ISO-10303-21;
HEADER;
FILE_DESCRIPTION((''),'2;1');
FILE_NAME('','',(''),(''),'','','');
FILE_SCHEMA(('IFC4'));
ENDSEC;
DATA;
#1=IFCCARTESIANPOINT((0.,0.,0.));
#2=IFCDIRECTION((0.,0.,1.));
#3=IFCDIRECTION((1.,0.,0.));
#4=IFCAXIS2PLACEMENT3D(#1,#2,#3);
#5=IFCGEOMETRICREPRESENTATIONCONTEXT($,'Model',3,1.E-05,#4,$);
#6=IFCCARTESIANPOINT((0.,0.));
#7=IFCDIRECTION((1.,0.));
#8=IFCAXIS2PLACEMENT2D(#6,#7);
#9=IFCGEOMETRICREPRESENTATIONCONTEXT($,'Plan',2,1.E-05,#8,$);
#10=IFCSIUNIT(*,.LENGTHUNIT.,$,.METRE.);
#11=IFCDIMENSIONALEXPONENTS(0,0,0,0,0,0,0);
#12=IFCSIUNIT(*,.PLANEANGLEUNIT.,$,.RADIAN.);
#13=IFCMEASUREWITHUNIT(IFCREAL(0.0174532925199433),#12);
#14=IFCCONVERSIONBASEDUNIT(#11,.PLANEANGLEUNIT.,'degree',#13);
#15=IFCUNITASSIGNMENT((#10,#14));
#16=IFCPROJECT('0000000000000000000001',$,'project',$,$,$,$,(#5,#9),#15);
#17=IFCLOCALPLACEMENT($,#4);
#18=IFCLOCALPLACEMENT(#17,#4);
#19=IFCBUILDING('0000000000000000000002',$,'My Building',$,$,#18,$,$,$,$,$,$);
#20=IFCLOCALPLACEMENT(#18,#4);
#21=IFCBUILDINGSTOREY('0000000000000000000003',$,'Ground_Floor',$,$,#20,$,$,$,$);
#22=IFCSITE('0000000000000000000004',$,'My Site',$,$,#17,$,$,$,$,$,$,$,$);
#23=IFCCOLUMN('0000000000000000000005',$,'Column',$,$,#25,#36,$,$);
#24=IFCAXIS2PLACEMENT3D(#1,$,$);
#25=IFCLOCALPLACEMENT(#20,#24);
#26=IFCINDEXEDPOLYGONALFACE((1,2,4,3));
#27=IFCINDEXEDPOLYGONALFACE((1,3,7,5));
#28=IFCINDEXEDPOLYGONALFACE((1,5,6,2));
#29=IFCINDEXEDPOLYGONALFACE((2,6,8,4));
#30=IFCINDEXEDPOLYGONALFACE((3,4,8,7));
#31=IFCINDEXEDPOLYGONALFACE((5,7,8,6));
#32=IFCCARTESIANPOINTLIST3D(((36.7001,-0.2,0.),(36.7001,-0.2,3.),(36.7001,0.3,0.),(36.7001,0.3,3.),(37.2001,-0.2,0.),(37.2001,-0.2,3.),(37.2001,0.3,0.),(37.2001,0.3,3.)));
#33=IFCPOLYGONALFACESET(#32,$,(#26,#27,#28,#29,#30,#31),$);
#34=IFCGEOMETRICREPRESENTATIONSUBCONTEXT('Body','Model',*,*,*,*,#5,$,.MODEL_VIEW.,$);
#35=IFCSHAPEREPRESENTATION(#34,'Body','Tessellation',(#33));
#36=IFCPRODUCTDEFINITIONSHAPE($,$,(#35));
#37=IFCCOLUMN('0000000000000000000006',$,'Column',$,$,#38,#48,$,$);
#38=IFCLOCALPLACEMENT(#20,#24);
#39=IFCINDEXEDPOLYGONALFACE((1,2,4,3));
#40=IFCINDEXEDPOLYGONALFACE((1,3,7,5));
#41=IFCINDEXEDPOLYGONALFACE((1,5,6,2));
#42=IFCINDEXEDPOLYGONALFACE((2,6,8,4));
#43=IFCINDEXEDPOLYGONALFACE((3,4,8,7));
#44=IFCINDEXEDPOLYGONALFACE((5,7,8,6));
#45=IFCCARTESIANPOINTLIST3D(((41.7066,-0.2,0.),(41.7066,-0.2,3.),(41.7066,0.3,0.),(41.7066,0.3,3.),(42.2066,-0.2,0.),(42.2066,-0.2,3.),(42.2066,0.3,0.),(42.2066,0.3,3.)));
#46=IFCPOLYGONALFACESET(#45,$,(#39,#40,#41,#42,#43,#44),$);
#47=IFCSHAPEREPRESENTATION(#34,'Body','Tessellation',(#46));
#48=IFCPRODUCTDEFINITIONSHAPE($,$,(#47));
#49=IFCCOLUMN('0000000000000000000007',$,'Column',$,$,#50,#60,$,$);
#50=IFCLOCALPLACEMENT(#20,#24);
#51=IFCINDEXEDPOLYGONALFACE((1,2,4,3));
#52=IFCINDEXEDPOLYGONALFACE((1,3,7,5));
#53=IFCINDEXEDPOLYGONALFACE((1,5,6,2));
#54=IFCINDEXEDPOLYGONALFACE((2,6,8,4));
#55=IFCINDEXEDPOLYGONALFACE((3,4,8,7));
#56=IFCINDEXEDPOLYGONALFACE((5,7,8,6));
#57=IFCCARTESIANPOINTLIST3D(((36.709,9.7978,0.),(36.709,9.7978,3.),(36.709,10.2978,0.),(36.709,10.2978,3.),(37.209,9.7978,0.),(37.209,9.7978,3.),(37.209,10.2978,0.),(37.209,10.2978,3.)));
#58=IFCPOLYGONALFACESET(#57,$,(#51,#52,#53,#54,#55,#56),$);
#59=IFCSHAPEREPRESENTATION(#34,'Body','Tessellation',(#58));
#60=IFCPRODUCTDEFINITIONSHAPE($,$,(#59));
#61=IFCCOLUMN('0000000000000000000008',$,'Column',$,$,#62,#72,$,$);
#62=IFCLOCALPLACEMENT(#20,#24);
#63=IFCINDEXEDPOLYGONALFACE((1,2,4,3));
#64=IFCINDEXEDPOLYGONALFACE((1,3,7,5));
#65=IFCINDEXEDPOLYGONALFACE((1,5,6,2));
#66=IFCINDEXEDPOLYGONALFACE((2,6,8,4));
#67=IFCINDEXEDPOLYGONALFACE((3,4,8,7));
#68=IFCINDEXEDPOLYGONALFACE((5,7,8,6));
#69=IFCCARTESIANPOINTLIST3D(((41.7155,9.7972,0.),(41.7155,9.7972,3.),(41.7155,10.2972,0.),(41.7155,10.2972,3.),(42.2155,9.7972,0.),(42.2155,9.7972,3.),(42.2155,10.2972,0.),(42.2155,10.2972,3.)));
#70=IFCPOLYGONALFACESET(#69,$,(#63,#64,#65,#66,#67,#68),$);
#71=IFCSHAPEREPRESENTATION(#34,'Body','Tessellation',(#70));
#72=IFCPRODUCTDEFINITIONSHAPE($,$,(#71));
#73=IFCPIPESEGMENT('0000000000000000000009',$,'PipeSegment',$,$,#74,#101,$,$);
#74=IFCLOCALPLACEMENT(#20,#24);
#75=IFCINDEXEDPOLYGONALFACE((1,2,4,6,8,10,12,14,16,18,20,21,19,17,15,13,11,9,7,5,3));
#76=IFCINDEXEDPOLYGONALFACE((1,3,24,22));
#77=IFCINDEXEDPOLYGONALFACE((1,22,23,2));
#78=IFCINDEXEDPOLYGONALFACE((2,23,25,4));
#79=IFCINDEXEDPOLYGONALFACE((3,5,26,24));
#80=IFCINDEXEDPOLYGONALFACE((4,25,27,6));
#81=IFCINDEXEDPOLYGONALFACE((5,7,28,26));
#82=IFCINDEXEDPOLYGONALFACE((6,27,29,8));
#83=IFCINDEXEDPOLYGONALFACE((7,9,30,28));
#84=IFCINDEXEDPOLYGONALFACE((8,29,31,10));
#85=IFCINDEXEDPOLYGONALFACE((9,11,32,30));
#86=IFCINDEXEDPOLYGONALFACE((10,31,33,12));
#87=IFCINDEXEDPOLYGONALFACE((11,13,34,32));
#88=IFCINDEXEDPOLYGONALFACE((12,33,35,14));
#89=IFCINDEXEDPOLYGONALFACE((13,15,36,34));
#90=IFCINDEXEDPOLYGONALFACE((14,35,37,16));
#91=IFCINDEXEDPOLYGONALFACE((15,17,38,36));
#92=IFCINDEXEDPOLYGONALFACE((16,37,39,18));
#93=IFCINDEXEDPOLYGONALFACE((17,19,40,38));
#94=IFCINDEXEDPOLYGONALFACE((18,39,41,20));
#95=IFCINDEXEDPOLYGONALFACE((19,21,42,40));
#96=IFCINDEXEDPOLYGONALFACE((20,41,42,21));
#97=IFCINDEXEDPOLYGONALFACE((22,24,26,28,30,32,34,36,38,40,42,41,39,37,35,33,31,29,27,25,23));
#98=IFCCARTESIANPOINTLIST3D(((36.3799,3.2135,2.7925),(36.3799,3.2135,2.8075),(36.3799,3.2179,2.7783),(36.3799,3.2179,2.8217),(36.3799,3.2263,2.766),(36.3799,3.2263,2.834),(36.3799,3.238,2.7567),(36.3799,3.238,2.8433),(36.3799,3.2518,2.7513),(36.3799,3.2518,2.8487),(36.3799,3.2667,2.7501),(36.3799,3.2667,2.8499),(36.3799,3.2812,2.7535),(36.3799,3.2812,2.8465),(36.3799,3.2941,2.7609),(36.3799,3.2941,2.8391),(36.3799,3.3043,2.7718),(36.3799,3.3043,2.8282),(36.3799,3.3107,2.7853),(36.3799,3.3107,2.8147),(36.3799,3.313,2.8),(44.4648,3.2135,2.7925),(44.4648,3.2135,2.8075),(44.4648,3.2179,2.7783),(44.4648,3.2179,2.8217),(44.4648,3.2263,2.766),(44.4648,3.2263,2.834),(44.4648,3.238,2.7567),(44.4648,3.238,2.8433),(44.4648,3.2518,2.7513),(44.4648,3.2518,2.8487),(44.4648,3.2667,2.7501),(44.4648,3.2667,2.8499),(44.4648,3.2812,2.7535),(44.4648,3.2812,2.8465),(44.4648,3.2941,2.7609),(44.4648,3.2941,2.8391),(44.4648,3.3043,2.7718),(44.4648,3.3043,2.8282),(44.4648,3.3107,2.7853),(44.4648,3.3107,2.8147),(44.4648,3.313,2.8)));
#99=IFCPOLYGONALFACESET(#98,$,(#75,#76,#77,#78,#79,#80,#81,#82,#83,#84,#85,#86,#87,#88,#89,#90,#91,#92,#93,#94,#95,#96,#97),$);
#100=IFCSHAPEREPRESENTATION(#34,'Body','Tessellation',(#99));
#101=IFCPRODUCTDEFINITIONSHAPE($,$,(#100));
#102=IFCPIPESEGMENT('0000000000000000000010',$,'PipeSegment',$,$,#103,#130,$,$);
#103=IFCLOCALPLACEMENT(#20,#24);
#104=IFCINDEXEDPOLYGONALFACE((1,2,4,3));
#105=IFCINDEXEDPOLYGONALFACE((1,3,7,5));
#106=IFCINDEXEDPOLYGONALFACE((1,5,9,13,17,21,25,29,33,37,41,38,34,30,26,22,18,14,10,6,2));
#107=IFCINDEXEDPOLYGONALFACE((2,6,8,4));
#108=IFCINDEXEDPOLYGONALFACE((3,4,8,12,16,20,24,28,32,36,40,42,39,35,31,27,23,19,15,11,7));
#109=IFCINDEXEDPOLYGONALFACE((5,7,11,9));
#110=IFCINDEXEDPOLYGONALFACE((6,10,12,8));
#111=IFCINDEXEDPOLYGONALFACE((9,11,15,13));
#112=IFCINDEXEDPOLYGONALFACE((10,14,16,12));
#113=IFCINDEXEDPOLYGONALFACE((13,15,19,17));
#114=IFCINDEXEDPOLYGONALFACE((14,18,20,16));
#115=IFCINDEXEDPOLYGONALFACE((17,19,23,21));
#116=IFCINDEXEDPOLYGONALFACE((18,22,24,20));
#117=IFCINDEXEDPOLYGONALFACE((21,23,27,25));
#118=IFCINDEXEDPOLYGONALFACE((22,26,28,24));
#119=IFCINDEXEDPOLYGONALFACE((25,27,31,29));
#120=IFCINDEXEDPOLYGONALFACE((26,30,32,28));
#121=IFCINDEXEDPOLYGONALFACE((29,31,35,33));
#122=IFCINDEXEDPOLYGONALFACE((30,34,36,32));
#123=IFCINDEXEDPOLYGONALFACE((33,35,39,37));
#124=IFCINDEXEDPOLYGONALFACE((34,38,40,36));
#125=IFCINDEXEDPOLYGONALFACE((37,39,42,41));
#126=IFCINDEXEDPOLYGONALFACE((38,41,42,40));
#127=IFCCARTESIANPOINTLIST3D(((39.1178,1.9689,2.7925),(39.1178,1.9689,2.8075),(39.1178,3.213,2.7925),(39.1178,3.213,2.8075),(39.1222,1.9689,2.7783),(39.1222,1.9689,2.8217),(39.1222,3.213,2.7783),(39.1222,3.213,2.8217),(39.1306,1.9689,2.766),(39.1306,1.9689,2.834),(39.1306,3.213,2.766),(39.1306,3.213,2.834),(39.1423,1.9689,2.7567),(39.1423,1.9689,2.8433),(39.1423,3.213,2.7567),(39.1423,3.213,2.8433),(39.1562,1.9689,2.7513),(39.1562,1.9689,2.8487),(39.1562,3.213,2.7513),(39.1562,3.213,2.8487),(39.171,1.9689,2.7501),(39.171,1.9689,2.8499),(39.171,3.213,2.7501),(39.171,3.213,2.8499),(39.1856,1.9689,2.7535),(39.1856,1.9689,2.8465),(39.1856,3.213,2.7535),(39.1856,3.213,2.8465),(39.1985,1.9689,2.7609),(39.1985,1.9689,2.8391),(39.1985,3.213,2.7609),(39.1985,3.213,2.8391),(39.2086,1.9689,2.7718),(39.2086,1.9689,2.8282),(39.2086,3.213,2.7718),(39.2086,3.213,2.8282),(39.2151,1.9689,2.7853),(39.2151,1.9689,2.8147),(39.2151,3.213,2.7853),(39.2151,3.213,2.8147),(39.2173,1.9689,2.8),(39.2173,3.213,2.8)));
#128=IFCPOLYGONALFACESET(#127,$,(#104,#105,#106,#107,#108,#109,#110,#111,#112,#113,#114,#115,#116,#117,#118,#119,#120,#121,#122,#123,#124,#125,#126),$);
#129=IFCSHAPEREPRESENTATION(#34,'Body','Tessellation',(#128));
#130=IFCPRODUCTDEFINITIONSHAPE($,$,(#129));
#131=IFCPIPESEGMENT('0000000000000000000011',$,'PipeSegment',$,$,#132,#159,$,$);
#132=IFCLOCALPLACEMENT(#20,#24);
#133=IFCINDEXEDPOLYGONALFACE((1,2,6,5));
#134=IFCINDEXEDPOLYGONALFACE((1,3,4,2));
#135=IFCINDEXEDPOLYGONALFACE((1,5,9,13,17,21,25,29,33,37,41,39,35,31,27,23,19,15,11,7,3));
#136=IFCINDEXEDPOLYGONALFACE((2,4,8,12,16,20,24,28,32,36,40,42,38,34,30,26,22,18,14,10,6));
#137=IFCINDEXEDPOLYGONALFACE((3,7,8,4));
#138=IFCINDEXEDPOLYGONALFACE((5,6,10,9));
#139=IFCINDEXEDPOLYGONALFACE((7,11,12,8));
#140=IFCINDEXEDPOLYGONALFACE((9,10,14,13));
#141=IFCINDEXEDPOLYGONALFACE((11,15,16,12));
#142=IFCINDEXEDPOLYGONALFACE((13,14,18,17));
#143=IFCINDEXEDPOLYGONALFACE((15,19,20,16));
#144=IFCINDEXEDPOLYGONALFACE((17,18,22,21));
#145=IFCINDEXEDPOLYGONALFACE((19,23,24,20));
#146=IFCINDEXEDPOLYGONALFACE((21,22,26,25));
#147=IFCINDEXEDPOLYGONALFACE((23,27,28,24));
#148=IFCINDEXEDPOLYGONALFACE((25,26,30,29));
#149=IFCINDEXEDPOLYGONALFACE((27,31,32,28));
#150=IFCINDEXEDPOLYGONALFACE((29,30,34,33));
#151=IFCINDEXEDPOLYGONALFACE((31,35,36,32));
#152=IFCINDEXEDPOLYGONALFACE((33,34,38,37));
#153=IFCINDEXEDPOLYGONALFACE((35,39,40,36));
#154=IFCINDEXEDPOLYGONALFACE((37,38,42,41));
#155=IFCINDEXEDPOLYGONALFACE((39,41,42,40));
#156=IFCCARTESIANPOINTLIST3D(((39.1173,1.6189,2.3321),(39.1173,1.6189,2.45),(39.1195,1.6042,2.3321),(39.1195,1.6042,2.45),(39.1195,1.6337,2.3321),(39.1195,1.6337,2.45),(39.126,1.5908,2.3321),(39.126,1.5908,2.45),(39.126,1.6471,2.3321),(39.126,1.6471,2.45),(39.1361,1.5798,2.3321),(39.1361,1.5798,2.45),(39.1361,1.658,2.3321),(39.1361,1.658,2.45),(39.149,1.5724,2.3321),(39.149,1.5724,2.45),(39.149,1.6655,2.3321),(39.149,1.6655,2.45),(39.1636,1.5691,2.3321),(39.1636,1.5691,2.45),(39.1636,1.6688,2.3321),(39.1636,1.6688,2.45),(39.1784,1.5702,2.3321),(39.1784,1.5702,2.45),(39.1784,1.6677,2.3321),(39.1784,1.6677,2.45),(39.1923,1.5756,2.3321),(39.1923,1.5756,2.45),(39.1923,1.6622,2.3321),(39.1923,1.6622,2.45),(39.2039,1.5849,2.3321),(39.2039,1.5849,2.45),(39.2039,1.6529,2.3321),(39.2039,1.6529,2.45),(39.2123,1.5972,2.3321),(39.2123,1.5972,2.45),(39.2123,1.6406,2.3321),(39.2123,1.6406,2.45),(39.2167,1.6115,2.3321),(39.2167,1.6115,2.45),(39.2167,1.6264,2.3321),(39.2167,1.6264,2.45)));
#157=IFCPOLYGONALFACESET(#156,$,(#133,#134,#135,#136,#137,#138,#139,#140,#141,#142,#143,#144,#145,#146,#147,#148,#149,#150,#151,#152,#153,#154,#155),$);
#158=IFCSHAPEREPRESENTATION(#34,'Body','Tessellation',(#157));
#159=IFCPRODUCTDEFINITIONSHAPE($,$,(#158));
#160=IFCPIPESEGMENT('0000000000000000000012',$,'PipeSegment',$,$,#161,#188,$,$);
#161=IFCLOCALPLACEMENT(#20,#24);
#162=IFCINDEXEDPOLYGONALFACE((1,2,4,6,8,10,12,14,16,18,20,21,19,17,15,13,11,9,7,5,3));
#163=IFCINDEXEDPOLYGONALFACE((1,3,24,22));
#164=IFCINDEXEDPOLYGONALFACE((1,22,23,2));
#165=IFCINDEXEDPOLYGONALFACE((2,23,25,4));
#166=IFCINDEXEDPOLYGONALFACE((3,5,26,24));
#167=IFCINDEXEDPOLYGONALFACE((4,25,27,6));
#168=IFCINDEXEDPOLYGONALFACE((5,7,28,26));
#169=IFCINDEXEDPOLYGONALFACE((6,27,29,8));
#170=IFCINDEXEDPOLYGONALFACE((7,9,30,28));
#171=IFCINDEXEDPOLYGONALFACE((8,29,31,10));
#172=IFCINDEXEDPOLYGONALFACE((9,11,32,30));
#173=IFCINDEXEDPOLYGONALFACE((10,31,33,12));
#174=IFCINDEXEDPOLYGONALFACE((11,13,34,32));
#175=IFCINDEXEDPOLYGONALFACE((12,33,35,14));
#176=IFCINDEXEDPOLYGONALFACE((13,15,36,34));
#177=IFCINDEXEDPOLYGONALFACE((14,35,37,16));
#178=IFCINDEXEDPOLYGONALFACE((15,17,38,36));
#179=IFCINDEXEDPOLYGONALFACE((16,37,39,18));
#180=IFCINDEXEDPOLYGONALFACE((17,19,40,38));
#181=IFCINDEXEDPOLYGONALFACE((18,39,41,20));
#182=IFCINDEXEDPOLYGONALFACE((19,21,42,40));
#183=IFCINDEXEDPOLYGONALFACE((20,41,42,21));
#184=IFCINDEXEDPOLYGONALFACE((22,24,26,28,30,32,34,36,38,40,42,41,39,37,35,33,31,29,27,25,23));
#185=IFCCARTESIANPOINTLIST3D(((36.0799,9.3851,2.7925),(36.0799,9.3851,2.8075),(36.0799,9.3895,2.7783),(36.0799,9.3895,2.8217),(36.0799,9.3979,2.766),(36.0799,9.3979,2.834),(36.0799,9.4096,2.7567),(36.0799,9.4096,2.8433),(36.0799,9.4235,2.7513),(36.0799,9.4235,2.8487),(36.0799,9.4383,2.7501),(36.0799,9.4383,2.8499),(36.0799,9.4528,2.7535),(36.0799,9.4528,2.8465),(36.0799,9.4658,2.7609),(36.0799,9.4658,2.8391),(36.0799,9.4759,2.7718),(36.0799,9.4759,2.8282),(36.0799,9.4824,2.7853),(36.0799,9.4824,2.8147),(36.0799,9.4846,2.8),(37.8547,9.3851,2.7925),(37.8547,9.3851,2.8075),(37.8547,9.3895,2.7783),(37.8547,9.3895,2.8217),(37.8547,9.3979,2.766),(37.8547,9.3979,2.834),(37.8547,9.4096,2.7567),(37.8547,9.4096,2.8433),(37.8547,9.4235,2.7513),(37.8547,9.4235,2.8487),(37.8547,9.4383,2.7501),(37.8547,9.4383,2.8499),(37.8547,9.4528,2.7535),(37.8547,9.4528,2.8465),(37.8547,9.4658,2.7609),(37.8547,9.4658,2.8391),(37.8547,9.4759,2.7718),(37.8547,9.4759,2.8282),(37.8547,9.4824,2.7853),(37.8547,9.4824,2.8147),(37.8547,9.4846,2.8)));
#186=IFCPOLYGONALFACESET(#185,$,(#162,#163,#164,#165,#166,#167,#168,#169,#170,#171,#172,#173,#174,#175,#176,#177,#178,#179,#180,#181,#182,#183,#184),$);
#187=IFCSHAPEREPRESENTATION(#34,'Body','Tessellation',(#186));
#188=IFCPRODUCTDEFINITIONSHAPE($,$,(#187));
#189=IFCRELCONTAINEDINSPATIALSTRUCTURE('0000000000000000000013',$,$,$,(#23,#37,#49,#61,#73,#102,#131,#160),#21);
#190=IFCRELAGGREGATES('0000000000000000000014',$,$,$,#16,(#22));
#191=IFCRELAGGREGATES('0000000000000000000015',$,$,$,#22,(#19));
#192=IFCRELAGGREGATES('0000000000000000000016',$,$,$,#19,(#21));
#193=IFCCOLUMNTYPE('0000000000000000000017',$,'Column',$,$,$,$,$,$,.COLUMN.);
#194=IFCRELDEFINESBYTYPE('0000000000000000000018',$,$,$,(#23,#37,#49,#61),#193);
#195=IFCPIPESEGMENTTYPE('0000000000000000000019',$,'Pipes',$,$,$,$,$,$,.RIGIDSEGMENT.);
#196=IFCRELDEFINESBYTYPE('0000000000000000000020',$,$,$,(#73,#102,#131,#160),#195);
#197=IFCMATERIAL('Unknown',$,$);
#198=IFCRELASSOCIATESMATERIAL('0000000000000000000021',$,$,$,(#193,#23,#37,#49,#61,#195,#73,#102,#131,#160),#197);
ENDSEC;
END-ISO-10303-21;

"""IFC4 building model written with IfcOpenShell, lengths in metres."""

from ifc_helpers import new_model, entity, si_unit, converted_unit, frame, origin_with_axes, origin_2d_with_axis, place, context, subcontext, project, spatial, rectangle, circle, extrude, material, material_profile, profile_set, profile_usage, type_object, element, save


model = new_model("IFC4")

# Units and contexts
model_context = context("Model", 3, precision=1e-05, world=origin_with_axes())
plan_context = context("Plan", 2, precision=1e-05, world=origin_2d_with_axis())
body_context = subcontext(model_context, "Body", "Model", "MODEL_VIEW")
ifc_project = project(units=[si_unit("LENGTHUNIT", "METRE"), converted_unit("PLANEANGLEUNIT", "degree", entity("IfcReal", 0.0174532925199433), si_unit("PLANEANGLEUNIT", "RADIAN"), dimensions=[0, 0, 0, 0, 0, 0, 0])], contexts=[model_context, plan_context])

# Site, building, storey
site_placement = place(None, origin_with_axes())
site = spatial("IfcSite", under=ifc_project, at=site_placement, Name="My Site")
building_placement = place(site_placement, origin_with_axes())
building = spatial("IfcBuilding", under=site, at=building_placement, Name="My Building")
storey_placement = place(building_placement, origin_with_axes())
storey = spatial("IfcBuildingStorey", under=building, at=storey_placement, Name="Ground_Floor")

# Columns
ifc_material = material(Name="Unknown")
ifc_material_profile_1 = material_profile(ifc_material, rectangle(XDim=0.5, YDim=0.5))
ifc_profile_set_1 = profile_set([ifc_material_profile_1])
ifc_profile_usage_1 = profile_usage(ifc_profile_set_1, cardinal=5)
column_type = type_object("IfcColumnType", Name="Column", PredefinedType="COLUMN", material=ifc_profile_set_1)
column_1_placement = place(storey_placement, frame((36.9501, 0.05, 0.0), z_axis=(0.0, 0.0, 1.0), x_axis=(1.0, 0.0, 0.0)))
element("IfcColumn", 1, at=column_1_placement, inside=storey, type_object=column_type, material=ifc_profile_usage_1, Name="Column", context=body_context, shape_type="SweptSolid", body=[
    extrude(rectangle(XDim=0.5, YDim=0.5), origin_with_axes(), (0.0, 0.0, 1.0), 3.0),
])
ifc_profile_usage_2 = profile_usage(ifc_profile_set_1, cardinal=5)
column_2_placement = place(storey_placement, frame((41.9566, 0.05, 0.0), z_axis=(0.0, 0.0, 1.0), x_axis=(1.0, 0.0, 0.0)))
element("IfcColumn", 2, at=column_2_placement, inside=storey, type_object=column_type, material=ifc_profile_usage_2, Name="Column", context=body_context, shape_type="SweptSolid", body=[
    extrude(rectangle(XDim=0.5, YDim=0.5), origin_with_axes(), (0.0, 0.0, 1.0), 3.0),
])
ifc_profile_usage_3 = profile_usage(ifc_profile_set_1, cardinal=5)
column_3_placement = place(storey_placement, frame((36.959, 10.0478, 0.0), z_axis=(0.0, 0.0, 1.0), x_axis=(1.0, 0.0, 0.0)))
element("IfcColumn", 3, at=column_3_placement, inside=storey, type_object=column_type, material=ifc_profile_usage_3, Name="Column", context=body_context, shape_type="SweptSolid", body=[
    extrude(rectangle(XDim=0.5, YDim=0.5), origin_with_axes(), (0.0, 0.0, 1.0), 3.0),
])
ifc_profile_usage_4 = profile_usage(ifc_profile_set_1, cardinal=5)
column_4_placement = place(storey_placement, frame((41.9655, 10.0472, 0.0), z_axis=(0.0, 0.0, 1.0), x_axis=(1.0, 0.0, 0.0)))
element("IfcColumn", 4, at=column_4_placement, inside=storey, type_object=column_type, material=ifc_profile_usage_4, Name="Column", context=body_context, shape_type="SweptSolid", body=[
    extrude(rectangle(XDim=0.5, YDim=0.5), origin_with_axes(), (0.0, 0.0, 1.0), 3.0),
])

# Pipe segments
ifc_material_profile_2 = material_profile(ifc_material, circle(Radius=0.05))
ifc_profile_set_2 = profile_set([ifc_material_profile_2])
ifc_profile_usage_5 = profile_usage(ifc_profile_set_2, cardinal=5)
pipe_segment_type = type_object("IfcPipeSegmentType", Name="Pipes", PredefinedType="RIGIDSEGMENT", material=ifc_profile_set_2)
pipe_segment_1_placement = place(storey_placement, frame((36.3799, 3.263, 2.8), z_axis=(1.0, 0.0, 0.0), x_axis=(0.0, 1.0, 0.0)))
element("IfcPipeSegment", 5, at=pipe_segment_1_placement, inside=storey, type_object=pipe_segment_type, material=ifc_profile_usage_5, Name="PipeSegment", context=body_context, shape_type="SweptSolid", body=[
    extrude(circle(Radius=0.05), origin_with_axes(), (0.0, 0.0, 1.0), 8.0849),
])
ifc_profile_usage_6 = profile_usage(ifc_profile_set_2, cardinal=5)
pipe_segment_2_placement = place(storey_placement, frame((39.1673, 3.213, 2.8), z_axis=(0.0, -1.0, 0.0), x_axis=(1.0, 0.0, 0.0)))
element("IfcPipeSegment", 6, at=pipe_segment_2_placement, inside=storey, type_object=pipe_segment_type, material=ifc_profile_usage_6, Name="PipeSegment", context=body_context, shape_type="SweptSolid", body=[
    extrude(circle(Radius=0.05), origin_with_axes(), (0.0, 0.0, 1.0), 1.244),
])
ifc_profile_usage_7 = profile_usage(ifc_profile_set_2, cardinal=5)
pipe_segment_3_placement = place(storey_placement, frame((39.1673, 1.6189, 2.45), z_axis=(0.0, 0.0, -1.0), x_axis=(-1.0, 0.0, 0.0)))
element("IfcPipeSegment", 7, at=pipe_segment_3_placement, inside=storey, type_object=pipe_segment_type, material=ifc_profile_usage_7, Name="PipeSegment", context=body_context, shape_type="SweptSolid", body=[
    extrude(circle(Radius=0.05), origin_with_axes(), (0.0, 0.0, 1.0), 0.1179),
])
ifc_profile_usage_8 = profile_usage(ifc_profile_set_2, cardinal=5)
pipe_segment_4_placement = place(storey_placement, frame((36.0799, 9.4346, 2.8), z_axis=(1.0, 0.0, 0.0), x_axis=(0.0, 1.0, 0.0)))
element("IfcPipeSegment", 8, at=pipe_segment_4_placement, inside=storey, type_object=pipe_segment_type, material=ifc_profile_usage_8, Name="PipeSegment", context=body_context, shape_type="SweptSolid", body=[
    extrude(circle(Radius=0.05), origin_with_axes(), (0.0, 0.0, 1.0), 1.7748),
])

save(model, "model.ifc")
